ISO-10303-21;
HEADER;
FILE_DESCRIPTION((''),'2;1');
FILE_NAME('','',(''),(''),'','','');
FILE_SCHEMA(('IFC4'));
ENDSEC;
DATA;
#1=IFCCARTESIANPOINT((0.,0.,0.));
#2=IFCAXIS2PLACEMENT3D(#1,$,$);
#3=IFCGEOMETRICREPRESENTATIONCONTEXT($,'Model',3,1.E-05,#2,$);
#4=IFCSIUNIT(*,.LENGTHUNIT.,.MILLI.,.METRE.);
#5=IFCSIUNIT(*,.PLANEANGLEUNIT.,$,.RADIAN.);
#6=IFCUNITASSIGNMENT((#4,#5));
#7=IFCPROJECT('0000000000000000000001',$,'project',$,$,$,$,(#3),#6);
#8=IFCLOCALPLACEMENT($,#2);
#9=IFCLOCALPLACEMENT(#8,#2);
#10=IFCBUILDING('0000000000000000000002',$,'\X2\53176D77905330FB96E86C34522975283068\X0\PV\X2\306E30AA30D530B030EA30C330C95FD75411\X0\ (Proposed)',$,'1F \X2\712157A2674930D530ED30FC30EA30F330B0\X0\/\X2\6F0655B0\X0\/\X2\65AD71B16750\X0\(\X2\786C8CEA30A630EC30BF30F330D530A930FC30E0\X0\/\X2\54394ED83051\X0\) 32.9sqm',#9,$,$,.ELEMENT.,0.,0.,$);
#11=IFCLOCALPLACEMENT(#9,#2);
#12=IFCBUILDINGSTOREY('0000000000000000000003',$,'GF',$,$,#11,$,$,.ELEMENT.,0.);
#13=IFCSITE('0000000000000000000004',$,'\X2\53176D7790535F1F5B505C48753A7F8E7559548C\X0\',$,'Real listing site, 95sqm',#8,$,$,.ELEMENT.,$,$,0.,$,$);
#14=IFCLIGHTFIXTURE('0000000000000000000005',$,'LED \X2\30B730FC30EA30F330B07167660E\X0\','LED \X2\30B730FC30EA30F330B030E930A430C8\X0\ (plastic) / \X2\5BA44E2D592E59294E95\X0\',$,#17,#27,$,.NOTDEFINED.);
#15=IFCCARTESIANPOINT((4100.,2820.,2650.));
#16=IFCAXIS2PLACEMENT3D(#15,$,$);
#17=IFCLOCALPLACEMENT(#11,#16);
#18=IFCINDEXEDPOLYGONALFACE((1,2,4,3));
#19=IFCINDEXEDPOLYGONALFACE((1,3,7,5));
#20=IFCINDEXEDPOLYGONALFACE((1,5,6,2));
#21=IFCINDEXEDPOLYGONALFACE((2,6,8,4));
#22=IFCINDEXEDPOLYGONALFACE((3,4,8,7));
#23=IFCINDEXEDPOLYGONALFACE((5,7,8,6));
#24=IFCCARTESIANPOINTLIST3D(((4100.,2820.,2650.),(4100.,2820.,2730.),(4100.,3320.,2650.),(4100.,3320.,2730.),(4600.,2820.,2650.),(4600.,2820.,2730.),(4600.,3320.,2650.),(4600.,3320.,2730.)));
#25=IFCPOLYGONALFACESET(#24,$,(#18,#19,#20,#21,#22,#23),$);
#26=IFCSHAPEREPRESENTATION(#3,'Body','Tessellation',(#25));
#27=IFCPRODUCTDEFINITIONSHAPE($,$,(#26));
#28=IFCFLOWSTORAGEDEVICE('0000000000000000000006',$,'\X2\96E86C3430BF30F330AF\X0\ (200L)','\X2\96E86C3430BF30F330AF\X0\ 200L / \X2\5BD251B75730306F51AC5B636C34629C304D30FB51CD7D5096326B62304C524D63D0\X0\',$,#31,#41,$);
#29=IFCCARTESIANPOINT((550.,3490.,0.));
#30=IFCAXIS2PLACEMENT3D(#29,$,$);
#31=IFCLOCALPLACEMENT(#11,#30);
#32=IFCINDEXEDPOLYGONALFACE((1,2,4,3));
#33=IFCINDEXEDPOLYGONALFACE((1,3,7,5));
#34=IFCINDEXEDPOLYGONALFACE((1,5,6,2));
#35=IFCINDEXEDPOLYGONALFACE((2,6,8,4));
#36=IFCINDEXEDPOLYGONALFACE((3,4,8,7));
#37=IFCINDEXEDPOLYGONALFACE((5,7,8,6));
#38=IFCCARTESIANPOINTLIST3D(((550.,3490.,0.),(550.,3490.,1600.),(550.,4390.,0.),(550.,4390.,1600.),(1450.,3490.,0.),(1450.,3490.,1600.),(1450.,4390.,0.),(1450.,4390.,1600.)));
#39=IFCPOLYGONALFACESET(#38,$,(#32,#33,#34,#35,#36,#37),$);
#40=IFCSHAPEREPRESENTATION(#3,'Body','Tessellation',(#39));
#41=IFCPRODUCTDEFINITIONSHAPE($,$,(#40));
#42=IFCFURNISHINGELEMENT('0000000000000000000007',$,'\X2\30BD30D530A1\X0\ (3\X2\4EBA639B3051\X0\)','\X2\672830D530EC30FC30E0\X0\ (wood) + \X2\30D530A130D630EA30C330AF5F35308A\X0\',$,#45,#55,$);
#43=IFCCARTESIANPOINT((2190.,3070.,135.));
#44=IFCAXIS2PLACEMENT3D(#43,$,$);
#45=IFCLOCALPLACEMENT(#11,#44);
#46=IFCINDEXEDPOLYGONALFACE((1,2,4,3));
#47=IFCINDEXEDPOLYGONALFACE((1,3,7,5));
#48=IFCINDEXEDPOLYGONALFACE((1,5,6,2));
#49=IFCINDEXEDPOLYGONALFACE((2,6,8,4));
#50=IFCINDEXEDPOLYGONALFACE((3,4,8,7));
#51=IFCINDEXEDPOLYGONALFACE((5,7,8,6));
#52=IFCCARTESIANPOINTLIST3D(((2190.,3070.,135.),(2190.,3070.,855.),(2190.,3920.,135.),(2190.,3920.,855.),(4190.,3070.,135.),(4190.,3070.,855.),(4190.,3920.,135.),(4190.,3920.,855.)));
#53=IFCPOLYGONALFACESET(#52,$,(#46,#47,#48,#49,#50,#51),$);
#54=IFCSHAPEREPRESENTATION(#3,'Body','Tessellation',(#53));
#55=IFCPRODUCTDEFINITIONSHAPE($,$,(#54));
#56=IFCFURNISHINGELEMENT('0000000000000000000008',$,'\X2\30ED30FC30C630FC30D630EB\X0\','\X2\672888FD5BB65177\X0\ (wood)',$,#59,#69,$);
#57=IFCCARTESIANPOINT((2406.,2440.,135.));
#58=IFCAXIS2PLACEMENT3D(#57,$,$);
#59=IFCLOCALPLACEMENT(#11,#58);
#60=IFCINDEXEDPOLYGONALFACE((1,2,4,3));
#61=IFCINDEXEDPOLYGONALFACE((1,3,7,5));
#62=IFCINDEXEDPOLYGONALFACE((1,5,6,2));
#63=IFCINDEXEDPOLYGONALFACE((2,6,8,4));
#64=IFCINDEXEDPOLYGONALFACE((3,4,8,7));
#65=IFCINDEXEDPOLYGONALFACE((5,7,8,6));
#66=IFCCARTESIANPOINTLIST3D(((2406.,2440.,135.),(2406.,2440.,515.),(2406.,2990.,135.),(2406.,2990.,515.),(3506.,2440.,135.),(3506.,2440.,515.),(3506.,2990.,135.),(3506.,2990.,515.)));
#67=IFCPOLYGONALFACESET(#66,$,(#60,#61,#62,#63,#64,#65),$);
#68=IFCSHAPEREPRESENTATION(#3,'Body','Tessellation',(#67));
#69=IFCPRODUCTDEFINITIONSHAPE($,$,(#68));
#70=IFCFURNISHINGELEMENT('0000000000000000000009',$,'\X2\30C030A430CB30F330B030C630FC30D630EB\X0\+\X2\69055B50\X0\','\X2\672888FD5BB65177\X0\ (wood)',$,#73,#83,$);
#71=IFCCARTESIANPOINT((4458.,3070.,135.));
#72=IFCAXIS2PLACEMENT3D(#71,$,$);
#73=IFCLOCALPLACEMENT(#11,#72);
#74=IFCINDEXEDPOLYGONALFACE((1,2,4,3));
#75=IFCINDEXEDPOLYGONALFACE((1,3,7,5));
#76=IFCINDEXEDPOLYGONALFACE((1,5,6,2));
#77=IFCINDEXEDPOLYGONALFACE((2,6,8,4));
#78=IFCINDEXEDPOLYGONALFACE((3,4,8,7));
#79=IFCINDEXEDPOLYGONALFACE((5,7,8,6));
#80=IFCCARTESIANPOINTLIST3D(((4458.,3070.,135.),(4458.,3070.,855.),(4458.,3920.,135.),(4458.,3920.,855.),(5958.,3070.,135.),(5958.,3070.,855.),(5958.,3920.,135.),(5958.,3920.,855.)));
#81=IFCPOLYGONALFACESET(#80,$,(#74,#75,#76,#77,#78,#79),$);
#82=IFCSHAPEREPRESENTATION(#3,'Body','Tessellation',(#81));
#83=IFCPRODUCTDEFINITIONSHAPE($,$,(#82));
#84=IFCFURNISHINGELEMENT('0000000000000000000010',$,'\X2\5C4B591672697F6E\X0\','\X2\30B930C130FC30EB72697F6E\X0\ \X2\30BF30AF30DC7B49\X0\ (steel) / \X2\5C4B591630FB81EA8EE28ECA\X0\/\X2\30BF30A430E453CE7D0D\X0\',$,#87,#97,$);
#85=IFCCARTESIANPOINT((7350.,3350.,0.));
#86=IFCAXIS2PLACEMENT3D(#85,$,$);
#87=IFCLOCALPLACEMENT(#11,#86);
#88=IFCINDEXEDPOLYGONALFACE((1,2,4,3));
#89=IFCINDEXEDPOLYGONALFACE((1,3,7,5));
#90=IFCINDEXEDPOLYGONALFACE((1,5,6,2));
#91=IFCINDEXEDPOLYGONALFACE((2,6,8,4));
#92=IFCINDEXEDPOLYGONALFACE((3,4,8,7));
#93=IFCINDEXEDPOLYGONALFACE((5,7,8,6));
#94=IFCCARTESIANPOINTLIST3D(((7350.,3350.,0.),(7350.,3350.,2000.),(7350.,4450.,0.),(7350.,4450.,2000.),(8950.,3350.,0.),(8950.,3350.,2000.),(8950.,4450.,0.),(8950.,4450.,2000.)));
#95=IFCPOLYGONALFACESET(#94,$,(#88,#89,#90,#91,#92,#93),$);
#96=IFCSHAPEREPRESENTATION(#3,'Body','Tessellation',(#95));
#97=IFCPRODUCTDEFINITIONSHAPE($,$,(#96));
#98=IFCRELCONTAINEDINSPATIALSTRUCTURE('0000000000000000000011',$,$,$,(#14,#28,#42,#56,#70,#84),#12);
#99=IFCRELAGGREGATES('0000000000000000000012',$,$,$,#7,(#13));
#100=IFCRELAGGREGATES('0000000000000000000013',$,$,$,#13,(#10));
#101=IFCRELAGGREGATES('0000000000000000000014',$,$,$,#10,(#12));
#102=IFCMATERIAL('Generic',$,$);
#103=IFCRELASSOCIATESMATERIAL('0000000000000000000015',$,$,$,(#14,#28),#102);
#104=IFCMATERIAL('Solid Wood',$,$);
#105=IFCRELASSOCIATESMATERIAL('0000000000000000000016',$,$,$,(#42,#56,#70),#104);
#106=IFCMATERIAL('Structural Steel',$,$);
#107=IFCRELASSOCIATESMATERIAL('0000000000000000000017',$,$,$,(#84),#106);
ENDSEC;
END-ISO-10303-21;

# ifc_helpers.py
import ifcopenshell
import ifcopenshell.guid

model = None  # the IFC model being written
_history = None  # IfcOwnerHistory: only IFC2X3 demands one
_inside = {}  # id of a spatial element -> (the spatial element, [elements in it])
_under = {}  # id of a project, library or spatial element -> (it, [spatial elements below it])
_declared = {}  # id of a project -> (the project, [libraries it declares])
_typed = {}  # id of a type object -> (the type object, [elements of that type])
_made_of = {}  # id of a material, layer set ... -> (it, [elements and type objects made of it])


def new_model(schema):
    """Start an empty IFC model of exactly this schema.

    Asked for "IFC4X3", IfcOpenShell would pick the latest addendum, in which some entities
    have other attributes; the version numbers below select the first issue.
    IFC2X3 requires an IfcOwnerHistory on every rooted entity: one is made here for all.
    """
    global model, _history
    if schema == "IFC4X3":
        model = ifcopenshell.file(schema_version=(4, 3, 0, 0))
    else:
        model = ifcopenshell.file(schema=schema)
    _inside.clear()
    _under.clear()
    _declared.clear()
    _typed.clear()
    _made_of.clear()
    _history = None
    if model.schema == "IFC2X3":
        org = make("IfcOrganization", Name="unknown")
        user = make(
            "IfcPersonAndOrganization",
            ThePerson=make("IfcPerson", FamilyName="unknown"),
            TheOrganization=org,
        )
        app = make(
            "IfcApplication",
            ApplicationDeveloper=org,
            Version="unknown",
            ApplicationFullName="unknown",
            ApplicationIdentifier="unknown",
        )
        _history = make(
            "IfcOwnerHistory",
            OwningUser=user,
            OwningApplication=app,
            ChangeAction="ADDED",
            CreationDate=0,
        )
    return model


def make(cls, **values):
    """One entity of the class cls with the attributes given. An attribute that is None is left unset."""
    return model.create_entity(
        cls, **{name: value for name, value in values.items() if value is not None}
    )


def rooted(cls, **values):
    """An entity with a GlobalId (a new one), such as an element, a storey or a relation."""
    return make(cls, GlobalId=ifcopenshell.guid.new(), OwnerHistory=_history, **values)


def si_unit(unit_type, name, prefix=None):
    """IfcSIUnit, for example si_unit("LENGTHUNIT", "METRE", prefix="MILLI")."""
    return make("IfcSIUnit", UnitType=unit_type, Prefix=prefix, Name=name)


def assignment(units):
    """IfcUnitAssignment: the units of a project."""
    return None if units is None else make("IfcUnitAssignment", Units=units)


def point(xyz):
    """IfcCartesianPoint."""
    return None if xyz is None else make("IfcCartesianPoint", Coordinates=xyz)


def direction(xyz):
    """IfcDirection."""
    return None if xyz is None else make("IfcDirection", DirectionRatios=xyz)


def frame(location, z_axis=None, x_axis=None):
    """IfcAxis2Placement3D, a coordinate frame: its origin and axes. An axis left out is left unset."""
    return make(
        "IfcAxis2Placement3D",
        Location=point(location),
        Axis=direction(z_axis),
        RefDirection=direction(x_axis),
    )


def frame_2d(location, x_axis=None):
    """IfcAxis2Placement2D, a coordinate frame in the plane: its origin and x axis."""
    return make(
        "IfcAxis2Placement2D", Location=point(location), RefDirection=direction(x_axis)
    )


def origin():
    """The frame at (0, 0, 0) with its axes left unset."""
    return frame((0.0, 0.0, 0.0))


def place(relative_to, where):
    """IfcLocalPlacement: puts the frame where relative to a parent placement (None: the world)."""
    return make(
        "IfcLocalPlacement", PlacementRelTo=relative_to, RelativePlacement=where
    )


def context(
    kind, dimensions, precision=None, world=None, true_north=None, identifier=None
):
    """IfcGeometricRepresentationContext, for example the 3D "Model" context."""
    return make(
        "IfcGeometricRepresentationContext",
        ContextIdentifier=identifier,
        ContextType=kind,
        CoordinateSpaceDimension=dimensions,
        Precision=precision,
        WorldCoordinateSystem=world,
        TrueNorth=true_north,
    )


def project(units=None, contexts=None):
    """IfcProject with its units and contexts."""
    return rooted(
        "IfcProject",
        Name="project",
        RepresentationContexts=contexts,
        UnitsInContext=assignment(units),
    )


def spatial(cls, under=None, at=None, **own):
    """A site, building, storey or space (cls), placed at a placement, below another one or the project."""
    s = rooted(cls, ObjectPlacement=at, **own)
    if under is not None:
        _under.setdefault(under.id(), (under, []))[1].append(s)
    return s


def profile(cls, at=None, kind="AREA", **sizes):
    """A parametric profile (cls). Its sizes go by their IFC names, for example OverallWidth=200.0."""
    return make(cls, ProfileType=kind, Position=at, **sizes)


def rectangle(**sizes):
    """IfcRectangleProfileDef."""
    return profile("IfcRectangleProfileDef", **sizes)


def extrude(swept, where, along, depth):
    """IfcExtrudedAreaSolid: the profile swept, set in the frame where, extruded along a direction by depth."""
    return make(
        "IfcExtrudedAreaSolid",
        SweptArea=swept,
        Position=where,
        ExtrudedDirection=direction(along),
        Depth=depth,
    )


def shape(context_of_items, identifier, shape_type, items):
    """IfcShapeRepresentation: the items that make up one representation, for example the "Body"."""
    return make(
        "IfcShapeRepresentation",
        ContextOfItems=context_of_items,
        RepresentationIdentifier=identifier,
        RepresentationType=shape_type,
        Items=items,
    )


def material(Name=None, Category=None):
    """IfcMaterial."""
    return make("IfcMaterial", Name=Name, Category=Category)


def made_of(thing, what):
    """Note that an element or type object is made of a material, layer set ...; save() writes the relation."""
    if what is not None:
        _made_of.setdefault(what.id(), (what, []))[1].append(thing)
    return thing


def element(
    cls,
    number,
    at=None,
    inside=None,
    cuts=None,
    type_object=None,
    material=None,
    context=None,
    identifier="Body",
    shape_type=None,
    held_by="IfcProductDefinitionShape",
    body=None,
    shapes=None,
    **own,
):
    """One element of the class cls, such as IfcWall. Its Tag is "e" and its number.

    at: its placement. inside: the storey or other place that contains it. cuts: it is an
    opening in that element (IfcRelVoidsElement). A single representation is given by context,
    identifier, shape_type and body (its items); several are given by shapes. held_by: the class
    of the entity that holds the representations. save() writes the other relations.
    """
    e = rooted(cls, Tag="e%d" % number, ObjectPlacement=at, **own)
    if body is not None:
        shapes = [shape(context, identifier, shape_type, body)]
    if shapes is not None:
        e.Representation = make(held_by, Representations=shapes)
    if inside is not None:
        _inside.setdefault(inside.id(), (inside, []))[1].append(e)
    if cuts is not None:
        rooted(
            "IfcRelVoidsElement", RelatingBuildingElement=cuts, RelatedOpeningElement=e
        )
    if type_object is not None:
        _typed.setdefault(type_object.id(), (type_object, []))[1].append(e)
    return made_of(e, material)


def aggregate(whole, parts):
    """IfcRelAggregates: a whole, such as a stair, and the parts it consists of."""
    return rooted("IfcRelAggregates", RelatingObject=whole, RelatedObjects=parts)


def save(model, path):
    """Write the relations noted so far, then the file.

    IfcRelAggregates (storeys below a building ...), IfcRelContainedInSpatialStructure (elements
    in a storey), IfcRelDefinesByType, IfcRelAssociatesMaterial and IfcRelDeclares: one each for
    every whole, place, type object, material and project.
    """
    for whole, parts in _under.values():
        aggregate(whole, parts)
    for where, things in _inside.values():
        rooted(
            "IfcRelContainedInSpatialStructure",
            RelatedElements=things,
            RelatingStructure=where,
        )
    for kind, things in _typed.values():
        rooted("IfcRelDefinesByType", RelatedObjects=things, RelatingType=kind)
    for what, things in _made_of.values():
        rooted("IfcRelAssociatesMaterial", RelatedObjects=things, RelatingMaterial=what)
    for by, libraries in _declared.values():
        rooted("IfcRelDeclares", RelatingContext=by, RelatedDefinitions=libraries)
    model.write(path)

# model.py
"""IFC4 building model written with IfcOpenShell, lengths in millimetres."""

from ifc_helpers import new_model, si_unit, frame, frame_2d, origin, place, context, project, spatial, rectangle, extrude, material, element, save


model = new_model("IFC4")

# Units and contexts
model_context = context("Model", 3, precision=1e-05, world=origin())
ifc_project = project(units=[si_unit("LENGTHUNIT", "METRE", prefix="MILLI"), si_unit("PLANEANGLEUNIT", "RADIAN")], contexts=[model_context])

# Site, building, storey
site_placement = place(None, origin())
site = spatial("IfcSite", under=ifc_project, at=site_placement, Name="北海道弟子屈町美留和", ObjectType="Real listing site, 95sqm", CompositionType="ELEMENT", RefElevation=0.0)
building_placement = place(site_placement, origin())
building = spatial("IfcBuilding", under=site, at=building_placement, Name="北海道・雨水利用とPVのオフグリッド志向 (Proposed)", ObjectType="1F 無垢杉フローリング/漆喰/断熱材(硬質ウレタンフォーム/吹付け) 32.9sqm", CompositionType="ELEMENT", ElevationOfRefHeight=0.0, ElevationOfTerrain=0.0)
storey_placement = place(building_placement, origin())
storey = spatial("IfcBuildingStorey", under=building, at=storey_placement, Name="GF", CompositionType="ELEMENT", Elevation=0.0)

# Shared definitions
ifc_material_1 = material(Name="Solid Wood")

# Shared definitions
ifc_material_2 = material(Name="Structural Steel")

# Light fixture
ifc_material_3 = material(Name="Generic")
light_fixture_placement = place(storey_placement, frame((4100.0, 2820.0, 2650.0)))
element("IfcLightFixture", 1, at=light_fixture_placement, inside=storey, material=ifc_material_3, Name="LED シーリング照明", Description="LED シーリングライト (plastic) / 室中央天井", PredefinedType="NOTDEFINED", context=model_context, shape_type="SweptSolid", body=[
    extrude(rectangle(XDim=500.0, YDim=500.0, at=frame_2d((250.0, 250.0))), frame((4100.0, 2820.0, 2650.0)), (0.0, 0.0, 1.0), 80.0),
])

# Flow storage device
flow_storage_device_placement = place(storey_placement, frame((550.0, 3490.0, 0.0)))
element("IfcFlowStorageDevice", 2, at=flow_storage_device_placement, inside=storey, material=ifc_material_3, Name="雨水タンク (200L)", Description="雨水タンク 200L / 寒冷地は冬季水抜き・凍結防止が前提", context=model_context, shape_type="SweptSolid", body=[
    extrude(rectangle(XDim=900.0, YDim=900.0, at=frame_2d((450.0, 450.0))), frame((550.0, 3490.0, 0.0)), (0.0, 0.0, 1.0), 1600.0),
])

# Furnishing elements
furnishing_1_placement = place(storey_placement, frame((2190.0, 3070.0, 135.0)))
element("IfcFurnishingElement", 3, at=furnishing_1_placement, inside=storey, material=ifc_material_1, Name="ソファ (3人掛け)", Description="木フレーム (wood) + ファブリック張り", context=model_context, shape_type="SweptSolid", body=[
    extrude(rectangle(XDim=2000.0, YDim=850.0, at=frame_2d((1000.0, 425.0))), frame((2190.0, 3070.0, 135.0)), (0.0, 0.0, 1.0), 720.0),
])
furnishing_2_placement = place(storey_placement, frame((2406.0, 2440.0, 135.0)))
element("IfcFurnishingElement", 4, at=furnishing_2_placement, inside=storey, material=ifc_material_1, Name="ローテーブル", Description="木製家具 (wood)", context=model_context, shape_type="SweptSolid", body=[
    extrude(rectangle(XDim=1100.0, YDim=550.0, at=frame_2d((550.0, 275.0))), frame((2406.0, 2440.0, 135.0)), (0.0, 0.0, 1.0), 380.0),
])
furnishing_3_placement = place(storey_placement, frame((4458.0, 3070.0, 135.0)))
element("IfcFurnishingElement", 5, at=furnishing_3_placement, inside=storey, material=ifc_material_1, Name="ダイニングテーブル+椅子", Description="木製家具 (wood)", context=model_context, shape_type="SweptSolid", body=[
    extrude(rectangle(XDim=1500.0, YDim=850.0, at=frame_2d((750.0, 425.0))), frame((4458.0, 3070.0, 135.0)), (0.0, 0.0, 1.0), 720.0),
])
furnishing_4_placement = place(storey_placement, frame((7350.0, 3350.0, 0.0)))
element("IfcFurnishingElement", 6, at=furnishing_4_placement, inside=storey, material=ifc_material_2, Name="屋外物置", Description="スチール物置 タクボ等 (steel) / 屋外・自転車/タイヤ収納", context=model_context, shape_type="SweptSolid", body=[
    extrude(rectangle(XDim=1600.0, YDim=1100.0, at=frame_2d((800.0, 550.0))), frame((7350.0, 3350.0, 0.0)), (0.0, 0.0, 1.0), 2000.0),
])

save(model, "model.ifc")
